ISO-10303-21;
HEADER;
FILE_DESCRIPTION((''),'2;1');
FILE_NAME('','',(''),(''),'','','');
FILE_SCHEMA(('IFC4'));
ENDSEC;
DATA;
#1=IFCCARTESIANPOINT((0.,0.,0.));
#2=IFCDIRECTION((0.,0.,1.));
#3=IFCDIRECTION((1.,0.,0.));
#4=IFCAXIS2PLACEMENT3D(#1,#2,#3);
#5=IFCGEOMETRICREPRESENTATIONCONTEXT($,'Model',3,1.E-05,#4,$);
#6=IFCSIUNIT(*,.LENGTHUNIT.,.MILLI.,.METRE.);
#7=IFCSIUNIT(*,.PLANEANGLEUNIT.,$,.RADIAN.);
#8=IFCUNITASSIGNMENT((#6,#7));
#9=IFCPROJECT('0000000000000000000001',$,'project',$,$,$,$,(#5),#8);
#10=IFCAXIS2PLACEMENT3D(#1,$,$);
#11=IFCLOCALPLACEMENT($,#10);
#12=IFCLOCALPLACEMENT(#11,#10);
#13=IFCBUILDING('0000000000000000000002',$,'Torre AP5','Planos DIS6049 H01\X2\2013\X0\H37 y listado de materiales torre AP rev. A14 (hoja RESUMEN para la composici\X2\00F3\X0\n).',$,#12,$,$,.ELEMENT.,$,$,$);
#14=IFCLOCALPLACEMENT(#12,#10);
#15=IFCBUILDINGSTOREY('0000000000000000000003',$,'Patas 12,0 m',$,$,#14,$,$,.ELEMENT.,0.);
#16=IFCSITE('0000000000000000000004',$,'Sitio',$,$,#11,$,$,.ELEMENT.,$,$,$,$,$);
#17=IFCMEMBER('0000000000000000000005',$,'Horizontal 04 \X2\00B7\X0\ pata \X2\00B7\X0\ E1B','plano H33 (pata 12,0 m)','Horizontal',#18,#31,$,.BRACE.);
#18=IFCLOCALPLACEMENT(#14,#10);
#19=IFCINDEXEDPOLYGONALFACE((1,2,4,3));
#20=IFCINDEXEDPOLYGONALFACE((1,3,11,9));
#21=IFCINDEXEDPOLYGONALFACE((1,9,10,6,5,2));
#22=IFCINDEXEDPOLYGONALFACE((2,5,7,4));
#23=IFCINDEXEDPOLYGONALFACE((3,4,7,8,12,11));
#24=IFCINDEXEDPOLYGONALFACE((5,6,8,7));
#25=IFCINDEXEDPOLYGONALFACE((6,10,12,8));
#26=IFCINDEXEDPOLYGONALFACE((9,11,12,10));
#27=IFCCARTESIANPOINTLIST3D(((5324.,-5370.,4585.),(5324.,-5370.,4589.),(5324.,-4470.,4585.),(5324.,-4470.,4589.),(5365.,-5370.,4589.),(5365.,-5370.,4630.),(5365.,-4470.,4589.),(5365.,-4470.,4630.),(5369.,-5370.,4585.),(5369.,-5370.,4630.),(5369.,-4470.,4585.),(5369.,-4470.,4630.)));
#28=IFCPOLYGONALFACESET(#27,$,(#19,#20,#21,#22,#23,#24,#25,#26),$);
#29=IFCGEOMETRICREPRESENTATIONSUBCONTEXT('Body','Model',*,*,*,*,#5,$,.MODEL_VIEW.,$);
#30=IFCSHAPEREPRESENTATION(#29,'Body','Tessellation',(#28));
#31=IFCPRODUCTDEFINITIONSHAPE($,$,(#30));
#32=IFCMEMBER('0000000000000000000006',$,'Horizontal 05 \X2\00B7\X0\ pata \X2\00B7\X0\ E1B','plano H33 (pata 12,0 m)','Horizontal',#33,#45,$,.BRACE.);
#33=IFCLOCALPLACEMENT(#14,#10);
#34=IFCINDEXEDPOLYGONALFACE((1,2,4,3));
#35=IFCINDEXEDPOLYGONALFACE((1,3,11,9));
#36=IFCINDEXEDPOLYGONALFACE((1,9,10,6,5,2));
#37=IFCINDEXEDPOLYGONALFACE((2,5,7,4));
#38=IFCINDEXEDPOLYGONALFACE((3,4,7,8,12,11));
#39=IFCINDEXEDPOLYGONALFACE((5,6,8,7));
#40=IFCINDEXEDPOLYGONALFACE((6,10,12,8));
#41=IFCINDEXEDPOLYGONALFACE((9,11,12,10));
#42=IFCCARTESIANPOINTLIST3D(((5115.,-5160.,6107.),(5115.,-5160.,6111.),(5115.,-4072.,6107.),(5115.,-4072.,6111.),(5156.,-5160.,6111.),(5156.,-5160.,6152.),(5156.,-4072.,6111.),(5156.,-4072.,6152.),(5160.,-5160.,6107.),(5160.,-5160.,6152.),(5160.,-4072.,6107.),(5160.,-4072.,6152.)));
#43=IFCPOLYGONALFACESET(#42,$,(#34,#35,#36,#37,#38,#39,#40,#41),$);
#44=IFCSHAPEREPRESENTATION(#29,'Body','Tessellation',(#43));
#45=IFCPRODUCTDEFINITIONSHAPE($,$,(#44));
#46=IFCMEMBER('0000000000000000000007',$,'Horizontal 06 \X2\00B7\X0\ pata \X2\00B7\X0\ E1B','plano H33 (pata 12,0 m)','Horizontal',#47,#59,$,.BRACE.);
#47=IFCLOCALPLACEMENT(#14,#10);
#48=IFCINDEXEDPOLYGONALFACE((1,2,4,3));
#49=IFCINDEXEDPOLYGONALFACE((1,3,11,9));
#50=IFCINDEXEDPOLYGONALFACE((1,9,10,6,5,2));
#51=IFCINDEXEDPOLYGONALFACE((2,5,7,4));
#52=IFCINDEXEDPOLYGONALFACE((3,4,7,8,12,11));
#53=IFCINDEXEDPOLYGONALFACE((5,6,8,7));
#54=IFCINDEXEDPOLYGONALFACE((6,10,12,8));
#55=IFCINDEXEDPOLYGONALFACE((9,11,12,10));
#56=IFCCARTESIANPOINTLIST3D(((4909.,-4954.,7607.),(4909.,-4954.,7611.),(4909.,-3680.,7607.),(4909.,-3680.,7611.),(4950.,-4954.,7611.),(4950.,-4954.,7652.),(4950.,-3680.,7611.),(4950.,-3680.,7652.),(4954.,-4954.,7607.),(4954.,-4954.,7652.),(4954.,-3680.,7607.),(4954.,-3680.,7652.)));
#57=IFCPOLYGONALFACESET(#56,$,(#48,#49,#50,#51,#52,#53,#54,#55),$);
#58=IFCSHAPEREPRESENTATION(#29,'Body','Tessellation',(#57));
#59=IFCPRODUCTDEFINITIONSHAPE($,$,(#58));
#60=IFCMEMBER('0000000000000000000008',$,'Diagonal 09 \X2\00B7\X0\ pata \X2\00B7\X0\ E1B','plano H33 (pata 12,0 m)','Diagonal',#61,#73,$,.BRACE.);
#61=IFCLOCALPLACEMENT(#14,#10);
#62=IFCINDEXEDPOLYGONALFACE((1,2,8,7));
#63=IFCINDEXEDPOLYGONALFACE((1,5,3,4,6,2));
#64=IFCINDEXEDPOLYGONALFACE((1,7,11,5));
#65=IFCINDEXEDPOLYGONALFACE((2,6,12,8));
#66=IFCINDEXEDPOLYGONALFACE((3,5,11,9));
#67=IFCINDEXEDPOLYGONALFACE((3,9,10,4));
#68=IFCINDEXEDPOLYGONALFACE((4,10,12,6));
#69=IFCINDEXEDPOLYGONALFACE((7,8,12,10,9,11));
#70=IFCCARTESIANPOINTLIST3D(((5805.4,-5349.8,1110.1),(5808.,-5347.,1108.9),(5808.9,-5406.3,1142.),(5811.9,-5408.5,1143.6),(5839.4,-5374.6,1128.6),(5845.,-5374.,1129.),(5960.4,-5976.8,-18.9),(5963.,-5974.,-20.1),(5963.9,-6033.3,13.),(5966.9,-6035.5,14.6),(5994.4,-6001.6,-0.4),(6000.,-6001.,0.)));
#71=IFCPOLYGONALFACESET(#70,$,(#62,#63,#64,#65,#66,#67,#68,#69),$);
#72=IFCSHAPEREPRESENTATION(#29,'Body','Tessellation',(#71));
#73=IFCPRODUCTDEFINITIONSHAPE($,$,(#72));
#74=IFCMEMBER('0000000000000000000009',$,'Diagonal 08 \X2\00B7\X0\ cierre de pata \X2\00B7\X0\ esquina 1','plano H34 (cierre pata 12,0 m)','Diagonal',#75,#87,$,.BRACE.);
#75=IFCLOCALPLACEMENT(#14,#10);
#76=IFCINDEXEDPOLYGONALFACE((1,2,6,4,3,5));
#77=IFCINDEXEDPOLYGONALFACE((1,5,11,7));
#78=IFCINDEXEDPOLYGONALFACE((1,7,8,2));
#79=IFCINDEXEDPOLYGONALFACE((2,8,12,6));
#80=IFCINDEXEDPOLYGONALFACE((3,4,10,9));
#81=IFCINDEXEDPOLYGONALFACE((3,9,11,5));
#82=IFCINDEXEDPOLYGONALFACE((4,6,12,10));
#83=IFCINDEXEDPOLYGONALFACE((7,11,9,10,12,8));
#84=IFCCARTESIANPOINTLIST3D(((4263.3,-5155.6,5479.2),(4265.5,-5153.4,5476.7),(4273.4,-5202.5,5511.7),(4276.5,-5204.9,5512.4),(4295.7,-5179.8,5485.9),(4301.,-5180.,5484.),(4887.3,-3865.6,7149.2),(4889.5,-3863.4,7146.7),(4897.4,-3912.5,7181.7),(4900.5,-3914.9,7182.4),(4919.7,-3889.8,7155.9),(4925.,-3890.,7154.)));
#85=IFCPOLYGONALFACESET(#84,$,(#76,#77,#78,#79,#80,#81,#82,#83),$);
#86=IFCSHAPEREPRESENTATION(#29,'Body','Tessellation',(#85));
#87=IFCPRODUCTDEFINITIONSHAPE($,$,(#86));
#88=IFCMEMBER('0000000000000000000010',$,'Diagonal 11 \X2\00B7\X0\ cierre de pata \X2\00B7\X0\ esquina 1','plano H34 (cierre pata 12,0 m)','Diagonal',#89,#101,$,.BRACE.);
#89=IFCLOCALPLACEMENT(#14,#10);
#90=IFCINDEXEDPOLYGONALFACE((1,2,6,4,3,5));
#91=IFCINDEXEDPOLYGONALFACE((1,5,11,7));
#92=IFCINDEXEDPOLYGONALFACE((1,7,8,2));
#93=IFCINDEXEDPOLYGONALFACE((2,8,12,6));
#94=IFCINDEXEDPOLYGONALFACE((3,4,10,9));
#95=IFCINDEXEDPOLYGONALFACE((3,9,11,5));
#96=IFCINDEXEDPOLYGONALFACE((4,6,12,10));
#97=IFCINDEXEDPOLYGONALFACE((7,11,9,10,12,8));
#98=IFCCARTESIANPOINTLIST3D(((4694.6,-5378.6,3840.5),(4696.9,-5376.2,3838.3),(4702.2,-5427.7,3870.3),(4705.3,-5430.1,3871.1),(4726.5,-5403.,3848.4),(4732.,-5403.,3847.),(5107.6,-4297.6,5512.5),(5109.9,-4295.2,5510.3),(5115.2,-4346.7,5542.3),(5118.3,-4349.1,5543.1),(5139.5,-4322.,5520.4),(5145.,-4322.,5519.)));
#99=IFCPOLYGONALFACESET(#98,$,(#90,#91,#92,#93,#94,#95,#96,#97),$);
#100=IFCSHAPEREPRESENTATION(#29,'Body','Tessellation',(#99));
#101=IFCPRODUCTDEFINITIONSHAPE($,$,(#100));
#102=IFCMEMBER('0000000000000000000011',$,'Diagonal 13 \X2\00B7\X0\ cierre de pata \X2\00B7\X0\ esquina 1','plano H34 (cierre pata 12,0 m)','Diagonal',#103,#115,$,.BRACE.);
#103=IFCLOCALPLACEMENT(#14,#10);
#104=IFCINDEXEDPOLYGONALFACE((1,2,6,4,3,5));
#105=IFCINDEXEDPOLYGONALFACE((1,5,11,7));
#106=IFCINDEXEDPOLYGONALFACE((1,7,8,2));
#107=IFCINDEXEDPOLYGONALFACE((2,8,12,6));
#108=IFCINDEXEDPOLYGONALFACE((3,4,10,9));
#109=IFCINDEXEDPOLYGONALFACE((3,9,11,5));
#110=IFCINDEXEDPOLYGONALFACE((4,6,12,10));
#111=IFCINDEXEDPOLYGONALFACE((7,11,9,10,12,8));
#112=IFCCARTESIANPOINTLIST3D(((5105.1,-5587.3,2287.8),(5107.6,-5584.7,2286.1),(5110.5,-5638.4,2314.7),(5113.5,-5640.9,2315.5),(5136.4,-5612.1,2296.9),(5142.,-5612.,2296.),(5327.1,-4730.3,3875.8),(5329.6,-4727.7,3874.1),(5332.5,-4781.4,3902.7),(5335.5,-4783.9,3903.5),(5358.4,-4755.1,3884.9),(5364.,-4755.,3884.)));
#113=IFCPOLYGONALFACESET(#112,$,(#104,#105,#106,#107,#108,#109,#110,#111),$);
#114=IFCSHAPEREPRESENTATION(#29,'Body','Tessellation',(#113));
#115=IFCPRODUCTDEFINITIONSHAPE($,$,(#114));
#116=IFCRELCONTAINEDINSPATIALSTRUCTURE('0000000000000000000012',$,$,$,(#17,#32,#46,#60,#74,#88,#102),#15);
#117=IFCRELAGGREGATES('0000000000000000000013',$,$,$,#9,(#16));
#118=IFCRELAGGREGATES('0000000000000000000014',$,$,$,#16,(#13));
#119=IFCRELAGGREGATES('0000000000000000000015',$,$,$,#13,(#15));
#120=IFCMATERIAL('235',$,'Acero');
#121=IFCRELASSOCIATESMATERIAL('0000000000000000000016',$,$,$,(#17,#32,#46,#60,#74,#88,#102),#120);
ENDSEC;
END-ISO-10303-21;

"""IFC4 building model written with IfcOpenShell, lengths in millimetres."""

from ifc_helpers import new_model, si_unit, frame, frame_2d, origin, origin_with_axes, place, context, subcontext, project, spatial, l_section, extrude, material, element, save


model = new_model("IFC4")

# Units and contexts
model_context = context("Model", 3, precision=1e-05, world=origin_with_axes())
body_context = subcontext(model_context, "Body", "Model", "MODEL_VIEW")
ifc_project = project(units=[si_unit("LENGTHUNIT", "METRE", prefix="MILLI"), si_unit("PLANEANGLEUNIT", "RADIAN")], contexts=[model_context])

# Site, building, storey
site_placement = place(None, origin())
site = spatial("IfcSite", under=ifc_project, at=site_placement, Name="Sitio", CompositionType="ELEMENT")
building_placement = place(site_placement, origin())
building = spatial("IfcBuilding", under=site, at=building_placement, Name="Torre AP5", Description="Planos DIS6049 H01–H37 y listado de materiales torre AP rev. A14 (hoja RESUMEN para la composición).", CompositionType="ELEMENT")
storey_placement = place(building_placement, origin())
storey = spatial("IfcBuildingStorey", under=building, at=storey_placement, Name="Patas 12,0 m", CompositionType="ELEMENT", Elevation=0.0)

# Members
ifc_material_1 = material(Name="235", Category="Acero")
member_1_placement = place(storey_placement, frame((5369.0, -5370.0, 4585.0), z_axis=(0.0, 1.0, 0.0), x_axis=(-1.0, 0.0, 0.0)))
element("IfcMember", 1, at=member_1_placement, inside=storey, material=ifc_material_1, Name="Horizontal 04 · pata · E1B", Description="plano H33 (pata 12,0 m)", ObjectType="Horizontal", PredefinedType="BRACE", context=body_context, shape_type="SweptSolid", body=[
    extrude(l_section(Depth=45.0, Width=45.0, Thickness=4.0, at=frame_2d((22.5, 22.5))), None, (0.0, 0.0, 1.0), 900.0),
])
member_2_placement = place(storey_placement, frame((5160.0, -5160.0, 6107.0), z_axis=(0.0, 1.0, 0.0), x_axis=(-1.0, 0.0, 0.0)))
element("IfcMember", 2, at=member_2_placement, inside=storey, material=ifc_material_1, Name="Horizontal 05 · pata · E1B", Description="plano H33 (pata 12,0 m)", ObjectType="Horizontal", PredefinedType="BRACE", context=body_context, shape_type="SweptSolid", body=[
    extrude(l_section(Depth=45.0, Width=45.0, Thickness=4.0, at=frame_2d((22.5, 22.5))), None, (0.0, 0.0, 1.0), 1088.0),
])
member_3_placement = place(storey_placement, frame((4954.0, -4954.0, 7607.0), z_axis=(0.0, 1.0, 0.0), x_axis=(-1.0, 0.0, 0.0)))
element("IfcMember", 3, at=member_3_placement, inside=storey, material=ifc_material_1, Name="Horizontal 06 · pata · E1B", Description="plano H33 (pata 12,0 m)", ObjectType="Horizontal", PredefinedType="BRACE", context=body_context, shape_type="SweptSolid", body=[
    extrude(l_section(Depth=45.0, Width=45.0, Thickness=4.0, at=frame_2d((22.5, 22.5))), None, (0.0, 0.0, 1.0), 1274.0),
])
member_4_placement = place(storey_placement, frame((6000.0, -6001.0, 0.0), z_axis=(-0.119168, 0.482052, 0.868001), x_axis=(-0.73958, 0.54018, -0.40153)))
element("IfcMember", 4, at=member_4_placement, inside=storey, material=ifc_material_1, Name="Diagonal 09 · pata · E1B", Description="plano H33 (pata 12,0 m)", ObjectType="Diagonal", PredefinedType="BRACE", context=body_context, shape_type="SweptSolid", body=[
    extrude(l_section(Depth=50.0, Width=50.0, Thickness=4.0, at=frame_2d((25.0, 25.0))), None, (0.0, 0.0, 1.0), 1300.7),
])
member_5_placement = place(storey_placement, frame((4301.0, -5180.0, 5484.0), z_axis=(0.283567, 0.58622, 0.758905), x_axis=(-0.789705, 0.591712, -0.161995)))
element("IfcMember", 5, at=member_5_placement, inside=storey, material=ifc_material_1, Name="Diagonal 08 · cierre de pata · esquina 1", Description="plano H34 (cierre pata 12,0 m)", ObjectType="Diagonal", PredefinedType="BRACE", context=body_context, shape_type="SweptSolid", body=[
    extrude(l_section(Depth=45.0, Width=45.0, Thickness=4.0, at=frame_2d((22.5, 22.5))), None, (0.0, 0.0, 1.0), 2200.5),
])
member_6_placement = place(storey_placement, frame((4732.0, -5403.0, 3847.0), z_axis=(0.203108, 0.531622, 0.822268), x_axis=(-0.779508, 0.595989, -0.192779)))
element("IfcMember", 6, at=member_6_placement, inside=storey, material=ifc_material_1, Name="Diagonal 11 · cierre de pata · esquina 1", Description="plano H34 (cierre pata 12,0 m)", ObjectType="Diagonal", PredefinedType="BRACE", context=body_context, shape_type="SweptSolid", body=[
    extrude(l_section(Depth=45.0, Width=45.0, Thickness=4.0, at=frame_2d((22.5, 22.5))), None, (0.0, 0.0, 1.0), 2033.4),
])
member_7_placement = place(storey_placement, frame((5142.0, -5612.0, 2296.0), z_axis=(0.122106, 0.471372, 0.873441), x_axis=(-0.764761, 0.605619, -0.219923)))
element("IfcMember", 7, at=member_7_placement, inside=storey, material=ifc_material_1, Name="Diagonal 13 · cierre de pata · esquina 1", Description="plano H34 (cierre pata 12,0 m)", ObjectType="Diagonal", PredefinedType="BRACE", context=body_context, shape_type="SweptSolid", body=[
    extrude(l_section(Depth=45.0, Width=45.0, Thickness=4.0, at=frame_2d((22.5, 22.5))), None, (0.0, 0.0, 1.0), 1818.1),
])

save(model, "model.ifc")
